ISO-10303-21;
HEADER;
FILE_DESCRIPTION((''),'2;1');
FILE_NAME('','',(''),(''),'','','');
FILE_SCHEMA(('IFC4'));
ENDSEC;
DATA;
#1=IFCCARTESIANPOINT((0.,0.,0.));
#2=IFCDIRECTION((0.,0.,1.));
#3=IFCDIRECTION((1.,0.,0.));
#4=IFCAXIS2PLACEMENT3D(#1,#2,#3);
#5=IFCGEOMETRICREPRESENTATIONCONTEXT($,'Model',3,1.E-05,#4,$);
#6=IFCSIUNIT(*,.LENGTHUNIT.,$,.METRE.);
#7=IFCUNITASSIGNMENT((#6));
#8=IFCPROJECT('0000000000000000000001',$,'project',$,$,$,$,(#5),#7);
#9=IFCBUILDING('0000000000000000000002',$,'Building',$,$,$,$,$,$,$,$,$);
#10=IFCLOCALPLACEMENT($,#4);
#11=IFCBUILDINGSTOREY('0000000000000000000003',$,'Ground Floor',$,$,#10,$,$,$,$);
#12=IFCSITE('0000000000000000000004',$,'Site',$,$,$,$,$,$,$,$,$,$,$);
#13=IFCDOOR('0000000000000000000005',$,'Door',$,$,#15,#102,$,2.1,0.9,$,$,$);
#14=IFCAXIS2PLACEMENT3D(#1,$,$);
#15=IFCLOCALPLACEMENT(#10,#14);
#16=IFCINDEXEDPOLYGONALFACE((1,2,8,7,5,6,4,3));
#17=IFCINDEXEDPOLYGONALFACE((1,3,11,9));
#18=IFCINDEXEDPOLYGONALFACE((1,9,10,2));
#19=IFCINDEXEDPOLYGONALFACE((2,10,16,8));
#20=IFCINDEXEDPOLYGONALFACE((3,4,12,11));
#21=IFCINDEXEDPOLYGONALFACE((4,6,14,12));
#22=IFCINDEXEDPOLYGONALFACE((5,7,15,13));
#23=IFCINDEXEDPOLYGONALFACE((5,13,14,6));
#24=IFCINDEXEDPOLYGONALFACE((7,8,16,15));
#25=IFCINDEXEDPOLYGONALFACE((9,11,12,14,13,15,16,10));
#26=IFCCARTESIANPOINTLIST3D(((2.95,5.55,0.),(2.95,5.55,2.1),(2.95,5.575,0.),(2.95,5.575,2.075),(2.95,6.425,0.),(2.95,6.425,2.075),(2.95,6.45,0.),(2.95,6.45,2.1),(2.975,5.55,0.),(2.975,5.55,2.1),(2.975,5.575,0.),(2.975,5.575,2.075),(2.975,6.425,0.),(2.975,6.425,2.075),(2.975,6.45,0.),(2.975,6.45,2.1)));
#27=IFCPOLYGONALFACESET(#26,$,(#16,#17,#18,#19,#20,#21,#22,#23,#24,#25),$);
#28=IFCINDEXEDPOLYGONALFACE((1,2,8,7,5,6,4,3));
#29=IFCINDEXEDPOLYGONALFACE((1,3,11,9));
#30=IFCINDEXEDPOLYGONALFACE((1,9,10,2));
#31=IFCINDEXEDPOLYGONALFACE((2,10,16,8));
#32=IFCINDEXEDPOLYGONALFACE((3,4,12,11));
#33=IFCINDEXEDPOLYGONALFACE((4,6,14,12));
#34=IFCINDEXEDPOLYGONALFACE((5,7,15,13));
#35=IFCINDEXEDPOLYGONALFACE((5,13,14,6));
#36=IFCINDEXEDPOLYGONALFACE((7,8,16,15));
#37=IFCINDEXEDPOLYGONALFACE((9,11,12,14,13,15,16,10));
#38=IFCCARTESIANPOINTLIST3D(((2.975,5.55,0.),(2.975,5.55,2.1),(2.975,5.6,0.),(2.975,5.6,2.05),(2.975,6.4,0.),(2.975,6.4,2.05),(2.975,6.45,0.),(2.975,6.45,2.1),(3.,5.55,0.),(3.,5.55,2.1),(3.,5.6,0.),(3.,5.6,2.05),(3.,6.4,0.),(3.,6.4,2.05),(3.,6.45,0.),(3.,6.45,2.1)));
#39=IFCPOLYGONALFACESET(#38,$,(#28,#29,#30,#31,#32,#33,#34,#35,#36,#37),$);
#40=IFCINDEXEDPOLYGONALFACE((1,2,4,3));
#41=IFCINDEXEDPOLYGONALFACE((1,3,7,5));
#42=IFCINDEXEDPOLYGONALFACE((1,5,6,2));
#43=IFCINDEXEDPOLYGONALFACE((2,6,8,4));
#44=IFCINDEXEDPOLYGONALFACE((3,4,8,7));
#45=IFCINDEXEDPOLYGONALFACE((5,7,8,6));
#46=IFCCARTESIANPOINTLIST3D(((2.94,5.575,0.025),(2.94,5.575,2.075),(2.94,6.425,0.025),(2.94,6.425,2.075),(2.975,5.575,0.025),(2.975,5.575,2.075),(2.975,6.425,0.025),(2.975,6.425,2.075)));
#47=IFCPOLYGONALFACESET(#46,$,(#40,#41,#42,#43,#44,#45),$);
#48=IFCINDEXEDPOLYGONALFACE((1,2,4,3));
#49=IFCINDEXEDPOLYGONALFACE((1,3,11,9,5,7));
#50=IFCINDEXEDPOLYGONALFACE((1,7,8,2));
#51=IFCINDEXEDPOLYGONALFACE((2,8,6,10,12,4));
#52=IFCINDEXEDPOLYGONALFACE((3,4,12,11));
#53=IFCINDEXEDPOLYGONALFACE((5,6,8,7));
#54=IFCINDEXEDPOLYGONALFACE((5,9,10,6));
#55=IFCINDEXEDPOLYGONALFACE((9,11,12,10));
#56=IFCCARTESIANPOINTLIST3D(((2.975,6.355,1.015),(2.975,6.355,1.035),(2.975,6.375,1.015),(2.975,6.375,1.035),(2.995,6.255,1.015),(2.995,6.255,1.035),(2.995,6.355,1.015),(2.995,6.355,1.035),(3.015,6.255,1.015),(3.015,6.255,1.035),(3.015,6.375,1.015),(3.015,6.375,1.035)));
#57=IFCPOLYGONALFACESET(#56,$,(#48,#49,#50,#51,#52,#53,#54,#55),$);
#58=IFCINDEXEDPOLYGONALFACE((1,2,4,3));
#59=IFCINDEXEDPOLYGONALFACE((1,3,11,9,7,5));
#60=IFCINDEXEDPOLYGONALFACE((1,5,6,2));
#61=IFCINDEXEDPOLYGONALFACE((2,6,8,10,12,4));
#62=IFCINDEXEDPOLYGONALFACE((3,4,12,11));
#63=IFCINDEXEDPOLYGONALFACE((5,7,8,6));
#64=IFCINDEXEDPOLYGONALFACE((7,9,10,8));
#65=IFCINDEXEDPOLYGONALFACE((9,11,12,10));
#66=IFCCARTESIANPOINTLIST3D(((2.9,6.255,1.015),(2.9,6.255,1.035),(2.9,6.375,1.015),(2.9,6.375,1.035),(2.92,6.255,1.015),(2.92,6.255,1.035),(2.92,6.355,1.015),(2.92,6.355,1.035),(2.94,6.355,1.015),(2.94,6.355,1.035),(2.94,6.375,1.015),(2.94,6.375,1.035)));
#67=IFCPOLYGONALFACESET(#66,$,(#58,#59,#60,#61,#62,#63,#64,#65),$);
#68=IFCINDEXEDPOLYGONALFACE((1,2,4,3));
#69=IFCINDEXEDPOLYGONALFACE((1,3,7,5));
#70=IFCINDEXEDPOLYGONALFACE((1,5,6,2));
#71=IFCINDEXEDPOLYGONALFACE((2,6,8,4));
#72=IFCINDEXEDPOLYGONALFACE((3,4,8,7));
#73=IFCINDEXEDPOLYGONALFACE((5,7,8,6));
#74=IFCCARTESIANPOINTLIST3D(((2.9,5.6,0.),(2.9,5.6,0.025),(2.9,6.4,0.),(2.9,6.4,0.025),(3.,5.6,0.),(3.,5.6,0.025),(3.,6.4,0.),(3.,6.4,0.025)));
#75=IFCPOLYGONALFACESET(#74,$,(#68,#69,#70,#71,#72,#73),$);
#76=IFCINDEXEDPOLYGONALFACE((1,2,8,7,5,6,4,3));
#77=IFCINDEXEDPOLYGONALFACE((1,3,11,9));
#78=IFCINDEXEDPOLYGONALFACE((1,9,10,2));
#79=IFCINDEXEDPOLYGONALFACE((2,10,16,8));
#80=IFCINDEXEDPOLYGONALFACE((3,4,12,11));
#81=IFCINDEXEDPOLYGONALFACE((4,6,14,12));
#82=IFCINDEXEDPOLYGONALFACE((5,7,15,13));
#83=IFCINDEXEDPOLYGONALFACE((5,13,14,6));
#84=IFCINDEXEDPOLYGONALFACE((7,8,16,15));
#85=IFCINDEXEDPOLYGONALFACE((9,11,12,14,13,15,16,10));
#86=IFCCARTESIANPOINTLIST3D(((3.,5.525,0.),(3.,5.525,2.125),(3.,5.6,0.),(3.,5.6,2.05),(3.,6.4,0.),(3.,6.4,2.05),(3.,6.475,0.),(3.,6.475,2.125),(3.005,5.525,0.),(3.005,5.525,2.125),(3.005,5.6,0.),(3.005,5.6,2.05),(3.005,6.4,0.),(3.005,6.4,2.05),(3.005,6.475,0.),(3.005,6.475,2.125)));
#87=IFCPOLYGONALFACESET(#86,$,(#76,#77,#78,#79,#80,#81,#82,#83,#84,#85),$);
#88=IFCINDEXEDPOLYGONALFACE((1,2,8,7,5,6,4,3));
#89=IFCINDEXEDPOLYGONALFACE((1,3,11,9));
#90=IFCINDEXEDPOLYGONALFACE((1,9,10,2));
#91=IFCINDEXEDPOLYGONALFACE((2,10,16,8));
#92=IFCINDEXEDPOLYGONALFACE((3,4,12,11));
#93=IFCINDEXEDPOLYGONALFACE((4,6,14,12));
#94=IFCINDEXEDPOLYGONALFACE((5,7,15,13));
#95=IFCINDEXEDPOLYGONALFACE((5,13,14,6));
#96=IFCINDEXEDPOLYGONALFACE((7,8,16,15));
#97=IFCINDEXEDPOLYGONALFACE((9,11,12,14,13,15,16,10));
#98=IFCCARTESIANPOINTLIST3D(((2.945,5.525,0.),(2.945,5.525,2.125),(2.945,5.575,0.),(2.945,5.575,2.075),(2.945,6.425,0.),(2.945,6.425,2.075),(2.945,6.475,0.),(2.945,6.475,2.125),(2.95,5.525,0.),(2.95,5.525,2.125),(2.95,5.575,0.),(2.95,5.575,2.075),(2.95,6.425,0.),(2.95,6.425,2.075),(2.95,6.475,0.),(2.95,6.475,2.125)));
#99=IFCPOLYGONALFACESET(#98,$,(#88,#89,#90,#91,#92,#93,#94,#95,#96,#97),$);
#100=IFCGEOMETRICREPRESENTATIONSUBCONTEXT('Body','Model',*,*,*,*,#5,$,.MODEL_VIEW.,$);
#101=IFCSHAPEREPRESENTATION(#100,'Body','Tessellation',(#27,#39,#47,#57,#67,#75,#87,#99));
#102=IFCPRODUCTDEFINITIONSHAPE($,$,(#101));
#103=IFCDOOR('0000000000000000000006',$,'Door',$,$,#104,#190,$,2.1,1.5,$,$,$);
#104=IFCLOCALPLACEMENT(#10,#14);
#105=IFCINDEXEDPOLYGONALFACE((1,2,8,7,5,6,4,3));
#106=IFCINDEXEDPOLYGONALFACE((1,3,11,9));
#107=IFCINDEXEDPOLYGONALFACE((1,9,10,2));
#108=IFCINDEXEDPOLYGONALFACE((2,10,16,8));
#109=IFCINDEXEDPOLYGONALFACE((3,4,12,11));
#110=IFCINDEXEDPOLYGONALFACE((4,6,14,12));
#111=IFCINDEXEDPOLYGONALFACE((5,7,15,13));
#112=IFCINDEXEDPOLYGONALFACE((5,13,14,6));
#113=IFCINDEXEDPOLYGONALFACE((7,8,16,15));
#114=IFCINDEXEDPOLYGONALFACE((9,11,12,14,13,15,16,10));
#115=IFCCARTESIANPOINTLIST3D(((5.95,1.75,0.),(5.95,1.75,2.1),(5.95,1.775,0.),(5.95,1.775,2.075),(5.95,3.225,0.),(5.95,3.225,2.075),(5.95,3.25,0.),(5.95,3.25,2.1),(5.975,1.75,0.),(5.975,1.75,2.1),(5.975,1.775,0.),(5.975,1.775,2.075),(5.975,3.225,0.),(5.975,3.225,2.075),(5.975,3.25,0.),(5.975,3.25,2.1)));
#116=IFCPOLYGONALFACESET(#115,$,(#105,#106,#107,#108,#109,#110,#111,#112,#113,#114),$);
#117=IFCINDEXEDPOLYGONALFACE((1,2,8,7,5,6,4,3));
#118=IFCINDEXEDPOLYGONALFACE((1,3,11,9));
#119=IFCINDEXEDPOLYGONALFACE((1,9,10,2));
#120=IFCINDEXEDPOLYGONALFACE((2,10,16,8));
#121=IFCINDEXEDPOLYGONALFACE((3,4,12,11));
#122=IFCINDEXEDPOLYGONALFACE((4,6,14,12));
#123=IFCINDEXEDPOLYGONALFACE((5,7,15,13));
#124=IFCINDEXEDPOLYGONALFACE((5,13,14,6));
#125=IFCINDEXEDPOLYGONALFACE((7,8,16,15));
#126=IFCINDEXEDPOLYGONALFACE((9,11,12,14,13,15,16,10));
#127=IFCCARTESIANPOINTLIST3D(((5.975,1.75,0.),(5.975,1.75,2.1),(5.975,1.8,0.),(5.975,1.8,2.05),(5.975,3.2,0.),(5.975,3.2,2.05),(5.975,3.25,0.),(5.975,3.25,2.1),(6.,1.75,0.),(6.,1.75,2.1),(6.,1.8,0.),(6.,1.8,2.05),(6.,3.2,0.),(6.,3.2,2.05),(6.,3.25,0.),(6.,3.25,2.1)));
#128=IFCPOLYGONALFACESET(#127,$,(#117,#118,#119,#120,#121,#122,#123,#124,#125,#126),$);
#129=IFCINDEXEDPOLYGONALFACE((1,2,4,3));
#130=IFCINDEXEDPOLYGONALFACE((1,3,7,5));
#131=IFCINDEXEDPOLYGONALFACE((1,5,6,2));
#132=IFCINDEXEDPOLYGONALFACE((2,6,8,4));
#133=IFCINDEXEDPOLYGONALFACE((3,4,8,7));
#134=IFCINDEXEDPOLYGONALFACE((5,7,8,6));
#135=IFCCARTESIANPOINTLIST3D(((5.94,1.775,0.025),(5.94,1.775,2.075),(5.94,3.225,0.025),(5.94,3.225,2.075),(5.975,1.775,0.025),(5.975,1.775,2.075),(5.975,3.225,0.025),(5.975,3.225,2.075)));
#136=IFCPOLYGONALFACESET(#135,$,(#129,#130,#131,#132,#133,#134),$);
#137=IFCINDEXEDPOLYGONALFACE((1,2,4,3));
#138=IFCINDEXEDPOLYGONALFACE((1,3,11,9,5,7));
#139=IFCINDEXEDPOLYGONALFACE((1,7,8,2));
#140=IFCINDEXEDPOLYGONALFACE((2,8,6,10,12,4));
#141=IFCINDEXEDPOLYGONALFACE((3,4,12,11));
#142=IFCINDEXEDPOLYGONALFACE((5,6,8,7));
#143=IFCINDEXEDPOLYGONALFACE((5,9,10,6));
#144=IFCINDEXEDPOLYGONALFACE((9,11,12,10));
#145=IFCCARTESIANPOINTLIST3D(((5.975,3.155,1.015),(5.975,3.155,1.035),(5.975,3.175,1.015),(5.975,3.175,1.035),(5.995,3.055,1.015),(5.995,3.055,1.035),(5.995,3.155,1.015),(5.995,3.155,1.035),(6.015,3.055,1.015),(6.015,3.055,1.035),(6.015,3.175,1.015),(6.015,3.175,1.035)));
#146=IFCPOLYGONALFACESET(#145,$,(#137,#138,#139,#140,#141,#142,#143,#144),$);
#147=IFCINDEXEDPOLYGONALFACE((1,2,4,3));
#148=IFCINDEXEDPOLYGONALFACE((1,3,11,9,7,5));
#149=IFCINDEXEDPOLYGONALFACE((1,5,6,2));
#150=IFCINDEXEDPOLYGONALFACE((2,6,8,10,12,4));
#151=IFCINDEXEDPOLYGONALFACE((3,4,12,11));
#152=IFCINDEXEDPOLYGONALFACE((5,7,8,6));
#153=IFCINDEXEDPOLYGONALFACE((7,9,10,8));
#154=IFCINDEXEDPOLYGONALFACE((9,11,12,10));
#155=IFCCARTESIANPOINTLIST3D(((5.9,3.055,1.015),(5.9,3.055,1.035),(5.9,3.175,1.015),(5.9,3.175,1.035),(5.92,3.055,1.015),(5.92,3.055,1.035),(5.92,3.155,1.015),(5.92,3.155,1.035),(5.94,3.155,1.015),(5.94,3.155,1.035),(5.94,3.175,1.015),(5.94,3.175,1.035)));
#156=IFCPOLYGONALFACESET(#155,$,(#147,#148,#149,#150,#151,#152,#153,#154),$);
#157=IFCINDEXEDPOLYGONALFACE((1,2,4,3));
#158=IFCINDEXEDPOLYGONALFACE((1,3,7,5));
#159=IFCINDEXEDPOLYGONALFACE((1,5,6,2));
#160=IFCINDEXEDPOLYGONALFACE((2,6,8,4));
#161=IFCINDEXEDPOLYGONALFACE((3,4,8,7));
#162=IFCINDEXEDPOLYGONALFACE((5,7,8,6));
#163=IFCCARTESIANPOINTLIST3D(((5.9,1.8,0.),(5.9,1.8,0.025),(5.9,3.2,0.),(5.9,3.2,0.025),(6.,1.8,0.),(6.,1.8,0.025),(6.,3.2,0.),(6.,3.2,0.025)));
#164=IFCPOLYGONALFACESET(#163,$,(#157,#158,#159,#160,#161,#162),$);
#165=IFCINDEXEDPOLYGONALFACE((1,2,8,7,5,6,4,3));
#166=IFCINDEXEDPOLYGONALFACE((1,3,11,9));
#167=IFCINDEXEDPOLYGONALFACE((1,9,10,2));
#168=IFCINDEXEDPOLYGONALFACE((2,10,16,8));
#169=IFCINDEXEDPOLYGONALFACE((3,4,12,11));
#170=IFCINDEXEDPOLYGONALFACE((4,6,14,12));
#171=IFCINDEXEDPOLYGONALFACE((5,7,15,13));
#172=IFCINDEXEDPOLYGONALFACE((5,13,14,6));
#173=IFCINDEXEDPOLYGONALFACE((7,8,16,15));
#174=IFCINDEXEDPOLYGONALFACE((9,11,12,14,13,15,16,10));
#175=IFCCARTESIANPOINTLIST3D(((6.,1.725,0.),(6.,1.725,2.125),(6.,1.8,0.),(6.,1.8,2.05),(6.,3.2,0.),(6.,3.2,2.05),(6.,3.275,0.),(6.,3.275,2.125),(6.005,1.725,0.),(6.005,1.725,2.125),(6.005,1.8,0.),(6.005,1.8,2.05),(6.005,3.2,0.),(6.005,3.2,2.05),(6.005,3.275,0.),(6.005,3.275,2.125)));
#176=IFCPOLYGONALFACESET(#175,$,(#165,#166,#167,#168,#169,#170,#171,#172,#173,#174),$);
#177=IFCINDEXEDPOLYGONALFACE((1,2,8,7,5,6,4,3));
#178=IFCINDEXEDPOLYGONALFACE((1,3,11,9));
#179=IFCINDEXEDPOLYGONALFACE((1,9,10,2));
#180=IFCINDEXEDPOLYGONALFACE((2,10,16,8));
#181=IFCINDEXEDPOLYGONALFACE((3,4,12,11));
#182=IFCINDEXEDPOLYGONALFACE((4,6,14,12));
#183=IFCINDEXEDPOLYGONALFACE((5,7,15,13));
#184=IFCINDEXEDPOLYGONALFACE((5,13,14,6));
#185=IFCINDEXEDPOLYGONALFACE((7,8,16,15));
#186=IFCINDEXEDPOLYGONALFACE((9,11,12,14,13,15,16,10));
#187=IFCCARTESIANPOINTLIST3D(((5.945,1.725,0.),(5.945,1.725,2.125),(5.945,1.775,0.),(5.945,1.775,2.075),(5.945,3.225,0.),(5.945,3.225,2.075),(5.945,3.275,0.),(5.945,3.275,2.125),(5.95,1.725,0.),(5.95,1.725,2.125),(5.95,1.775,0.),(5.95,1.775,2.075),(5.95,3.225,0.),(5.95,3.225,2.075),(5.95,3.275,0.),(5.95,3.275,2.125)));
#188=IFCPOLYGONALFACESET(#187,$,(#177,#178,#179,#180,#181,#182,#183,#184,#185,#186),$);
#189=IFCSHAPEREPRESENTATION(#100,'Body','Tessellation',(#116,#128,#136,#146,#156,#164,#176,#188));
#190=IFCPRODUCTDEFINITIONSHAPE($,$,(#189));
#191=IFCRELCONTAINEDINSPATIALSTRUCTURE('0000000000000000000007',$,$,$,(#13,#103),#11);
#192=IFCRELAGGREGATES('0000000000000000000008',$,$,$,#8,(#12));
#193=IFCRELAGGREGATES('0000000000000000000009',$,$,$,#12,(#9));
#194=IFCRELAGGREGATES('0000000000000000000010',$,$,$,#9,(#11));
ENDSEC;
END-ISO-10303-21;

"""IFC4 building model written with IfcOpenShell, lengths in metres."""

from ifc_helpers import new_model, si_unit, frame, origin_with_axes, place, context, subcontext, project, spatial, line, indexed_curve, outline, extrude, element, save


model = new_model("IFC4")

# Units and contexts
model_context = context("Model", 3, precision=1e-05, world=origin_with_axes())
body_context = subcontext(model_context, "Body", "Model", "MODEL_VIEW")
ifc_project = project(units=[si_unit("LENGTHUNIT", "METRE")], contexts=[model_context])

# Site, building, storey
site = spatial("IfcSite", under=ifc_project, Name="Site")
building = spatial("IfcBuilding", under=site, Name="Building")
storey_placement = place(None, origin_with_axes())
storey = spatial("IfcBuildingStorey", under=building, at=storey_placement, Name="Ground Floor")

# Doors
door_1_placement = place(storey_placement, frame((3.0, 5.55, 0.0), z_axis=(0.0, 0.0, 1.0), x_axis=(0.0, 1.0, 0.0)))
element("IfcDoor", 1, at=door_1_placement, inside=storey, Name="Door", OverallHeight=2.1, OverallWidth=0.9, context=body_context, shape_type="SweptSolid", body=[
    extrude(outline(indexed_curve([(0.0, 0.0), (0.0, 2.1), (0.9, 2.1), (0.9, 0.0), (0.875, 0.0), (0.875, 2.075), (0.025, 2.075), (0.025, 0.0)], segments=[line(1, 2, 3, 4, 5, 6, 7, 8, 1)])), frame((0.0, 0.025, 0.0), z_axis=(0.0, -1.0, 0.0), x_axis=(1.0, 0.0, 0.0)), (0.0, 0.0, -1.0), 0.025),
    extrude(outline(indexed_curve([(0.0, 0.0), (0.0, 2.1), (0.9, 2.1), (0.9, 0.0), (0.85, 0.0), (0.85, 2.05), (0.05, 2.05), (0.05, 0.0)], segments=[line(1, 2, 3, 4, 5, 6, 7, 8, 1)])), frame((0.0, 0.0, 0.0), z_axis=(0.0, -1.0, 0.0), x_axis=(1.0, 0.0, 0.0)), (0.0, 0.0, -1.0), 0.025),
    extrude(outline(indexed_curve([(0.0, 0.0), (0.85, 0.0), (0.85, 0.035), (0.0, 0.035)], segments=[line(1, 2, 3, 4, 1)])), frame((0.025, 0.025, 0.025), z_axis=(0.0, 0.0, 1.0), x_axis=(1.0, 0.0, 0.0)), (0.0, 0.0, 1.0), 2.05),
    extrude(outline(indexed_curve([(0.0, 0.0), (0.0, -0.04), (-0.12, -0.04), (-0.12, -0.02), (-0.02, -0.02), (-0.02, 0.0)], segments=[line(1, 2, 3, 4, 5, 6, 1)])), frame((0.825, 0.025, 1.015), z_axis=(0.0, 0.0, 1.0), x_axis=(1.0, 0.0, 0.0)), (0.0, 0.0, 1.0), 0.02),
    extrude(outline(indexed_curve([(0.0, 0.0), (0.0, 0.04), (-0.12, 0.04), (-0.12, 0.02), (-0.02, 0.02), (-0.02, 0.0)], segments=[line(1, 2, 3, 4, 5, 6, 1)])), frame((0.825, 0.06, 1.015), z_axis=(0.0, 0.0, 1.0), x_axis=(1.0, 0.0, 0.0)), (0.0, 0.0, 1.0), 0.02),
    extrude(outline(indexed_curve([(0.0, 0.0), (0.8, 0.0), (0.8, 0.1), (0.0, 0.1)], segments=[line(1, 2, 3, 4, 1)])), frame((0.05, 0.0, 0.0), z_axis=(0.0, 0.0, 1.0), x_axis=(1.0, 0.0, 0.0)), (0.0, 0.0, 1.0), 0.025),
    extrude(outline(indexed_curve([(0.0, 0.0), (0.0, 2.125), (0.95, 2.125), (0.95, 0.0), (0.875, 0.0), (0.875, 2.05), (0.075, 2.05), (0.075, 0.0)], segments=[line(1, 2, 3, 4, 5, 6, 7, 8, 1)])), frame((-0.025, -0.005, 0.0), z_axis=(0.0, -1.0, 0.0), x_axis=(1.0, 0.0, 0.0)), (0.0, 0.0, -1.0), 0.005),
    extrude(outline(indexed_curve([(0.0, 0.0), (0.0, 2.125), (0.95, 2.125), (0.95, 0.0), (0.9, 0.0), (0.9, 2.075), (0.05, 2.075), (0.05, 0.0)], segments=[line(1, 2, 3, 4, 5, 6, 7, 8, 1)])), frame((-0.025, 0.05, 0.0), z_axis=(0.0, -1.0, 0.0), x_axis=(1.0, 0.0, 0.0)), (0.0, 0.0, -1.0), 0.005),
])
door_2_placement = place(storey_placement, frame((6.0, 1.75, 0.0), z_axis=(0.0, 0.0, 1.0), x_axis=(0.0, 1.0, 0.0)))
element("IfcDoor", 2, at=door_2_placement, inside=storey, Name="Door", OverallHeight=2.1, OverallWidth=1.5, context=body_context, shape_type="SweptSolid", body=[
    extrude(outline(indexed_curve([(0.0, 0.0), (0.0, 2.1), (1.5, 2.1), (1.5, 0.0), (1.475, 0.0), (1.475, 2.075), (0.025, 2.075), (0.025, 0.0)], segments=[line(1, 2, 3, 4, 5, 6, 7, 8, 1)])), frame((0.0, 0.025, 0.0), z_axis=(0.0, -1.0, 0.0), x_axis=(1.0, 0.0, 0.0)), (0.0, 0.0, -1.0), 0.025),
    extrude(outline(indexed_curve([(0.0, 0.0), (0.0, 2.1), (1.5, 2.1), (1.5, 0.0), (1.45, 0.0), (1.45, 2.05), (0.05, 2.05), (0.05, 0.0)], segments=[line(1, 2, 3, 4, 5, 6, 7, 8, 1)])), frame((0.0, 0.0, 0.0), z_axis=(0.0, -1.0, 0.0), x_axis=(1.0, 0.0, 0.0)), (0.0, 0.0, -1.0), 0.025),
    extrude(outline(indexed_curve([(0.0, 0.0), (1.45, 0.0), (1.45, 0.035), (0.0, 0.035)], segments=[line(1, 2, 3, 4, 1)])), frame((0.025, 0.025, 0.025), z_axis=(0.0, 0.0, 1.0), x_axis=(1.0, 0.0, 0.0)), (0.0, 0.0, 1.0), 2.05),
    extrude(outline(indexed_curve([(0.0, 0.0), (0.0, -0.04), (-0.12, -0.04), (-0.12, -0.02), (-0.02, -0.02), (-0.02, 0.0)], segments=[line(1, 2, 3, 4, 5, 6, 1)])), frame((1.425, 0.025, 1.015), z_axis=(0.0, 0.0, 1.0), x_axis=(1.0, 0.0, 0.0)), (0.0, 0.0, 1.0), 0.02),
    extrude(outline(indexed_curve([(0.0, 0.0), (0.0, 0.04), (-0.12, 0.04), (-0.12, 0.02), (-0.02, 0.02), (-0.02, 0.0)], segments=[line(1, 2, 3, 4, 5, 6, 1)])), frame((1.425, 0.06, 1.015), z_axis=(0.0, 0.0, 1.0), x_axis=(1.0, 0.0, 0.0)), (0.0, 0.0, 1.0), 0.02),
    extrude(outline(indexed_curve([(0.0, 0.0), (1.4, 0.0), (1.4, 0.1), (0.0, 0.1)], segments=[line(1, 2, 3, 4, 1)])), frame((0.05, 0.0, 0.0), z_axis=(0.0, 0.0, 1.0), x_axis=(1.0, 0.0, 0.0)), (0.0, 0.0, 1.0), 0.025),
    extrude(outline(indexed_curve([(0.0, 0.0), (0.0, 2.125), (1.55, 2.125), (1.55, 0.0), (1.475, 0.0), (1.475, 2.05), (0.075, 2.05), (0.075, 0.0)], segments=[line(1, 2, 3, 4, 5, 6, 7, 8, 1)])), frame((-0.025, -0.005, 0.0), z_axis=(0.0, -1.0, 0.0), x_axis=(1.0, 0.0, 0.0)), (0.0, 0.0, -1.0), 0.005),
    extrude(outline(indexed_curve([(0.0, 0.0), (0.0, 2.125), (1.55, 2.125), (1.55, 0.0), (1.5, 0.0), (1.5, 2.075), (0.05, 2.075), (0.05, 0.0)], segments=[line(1, 2, 3, 4, 5, 6, 7, 8, 1)])), frame((-0.025, 0.05, 0.0), z_axis=(0.0, -1.0, 0.0), x_axis=(1.0, 0.0, 0.0)), (0.0, 0.0, -1.0), 0.005),
])

save(model, "model.ifc")
